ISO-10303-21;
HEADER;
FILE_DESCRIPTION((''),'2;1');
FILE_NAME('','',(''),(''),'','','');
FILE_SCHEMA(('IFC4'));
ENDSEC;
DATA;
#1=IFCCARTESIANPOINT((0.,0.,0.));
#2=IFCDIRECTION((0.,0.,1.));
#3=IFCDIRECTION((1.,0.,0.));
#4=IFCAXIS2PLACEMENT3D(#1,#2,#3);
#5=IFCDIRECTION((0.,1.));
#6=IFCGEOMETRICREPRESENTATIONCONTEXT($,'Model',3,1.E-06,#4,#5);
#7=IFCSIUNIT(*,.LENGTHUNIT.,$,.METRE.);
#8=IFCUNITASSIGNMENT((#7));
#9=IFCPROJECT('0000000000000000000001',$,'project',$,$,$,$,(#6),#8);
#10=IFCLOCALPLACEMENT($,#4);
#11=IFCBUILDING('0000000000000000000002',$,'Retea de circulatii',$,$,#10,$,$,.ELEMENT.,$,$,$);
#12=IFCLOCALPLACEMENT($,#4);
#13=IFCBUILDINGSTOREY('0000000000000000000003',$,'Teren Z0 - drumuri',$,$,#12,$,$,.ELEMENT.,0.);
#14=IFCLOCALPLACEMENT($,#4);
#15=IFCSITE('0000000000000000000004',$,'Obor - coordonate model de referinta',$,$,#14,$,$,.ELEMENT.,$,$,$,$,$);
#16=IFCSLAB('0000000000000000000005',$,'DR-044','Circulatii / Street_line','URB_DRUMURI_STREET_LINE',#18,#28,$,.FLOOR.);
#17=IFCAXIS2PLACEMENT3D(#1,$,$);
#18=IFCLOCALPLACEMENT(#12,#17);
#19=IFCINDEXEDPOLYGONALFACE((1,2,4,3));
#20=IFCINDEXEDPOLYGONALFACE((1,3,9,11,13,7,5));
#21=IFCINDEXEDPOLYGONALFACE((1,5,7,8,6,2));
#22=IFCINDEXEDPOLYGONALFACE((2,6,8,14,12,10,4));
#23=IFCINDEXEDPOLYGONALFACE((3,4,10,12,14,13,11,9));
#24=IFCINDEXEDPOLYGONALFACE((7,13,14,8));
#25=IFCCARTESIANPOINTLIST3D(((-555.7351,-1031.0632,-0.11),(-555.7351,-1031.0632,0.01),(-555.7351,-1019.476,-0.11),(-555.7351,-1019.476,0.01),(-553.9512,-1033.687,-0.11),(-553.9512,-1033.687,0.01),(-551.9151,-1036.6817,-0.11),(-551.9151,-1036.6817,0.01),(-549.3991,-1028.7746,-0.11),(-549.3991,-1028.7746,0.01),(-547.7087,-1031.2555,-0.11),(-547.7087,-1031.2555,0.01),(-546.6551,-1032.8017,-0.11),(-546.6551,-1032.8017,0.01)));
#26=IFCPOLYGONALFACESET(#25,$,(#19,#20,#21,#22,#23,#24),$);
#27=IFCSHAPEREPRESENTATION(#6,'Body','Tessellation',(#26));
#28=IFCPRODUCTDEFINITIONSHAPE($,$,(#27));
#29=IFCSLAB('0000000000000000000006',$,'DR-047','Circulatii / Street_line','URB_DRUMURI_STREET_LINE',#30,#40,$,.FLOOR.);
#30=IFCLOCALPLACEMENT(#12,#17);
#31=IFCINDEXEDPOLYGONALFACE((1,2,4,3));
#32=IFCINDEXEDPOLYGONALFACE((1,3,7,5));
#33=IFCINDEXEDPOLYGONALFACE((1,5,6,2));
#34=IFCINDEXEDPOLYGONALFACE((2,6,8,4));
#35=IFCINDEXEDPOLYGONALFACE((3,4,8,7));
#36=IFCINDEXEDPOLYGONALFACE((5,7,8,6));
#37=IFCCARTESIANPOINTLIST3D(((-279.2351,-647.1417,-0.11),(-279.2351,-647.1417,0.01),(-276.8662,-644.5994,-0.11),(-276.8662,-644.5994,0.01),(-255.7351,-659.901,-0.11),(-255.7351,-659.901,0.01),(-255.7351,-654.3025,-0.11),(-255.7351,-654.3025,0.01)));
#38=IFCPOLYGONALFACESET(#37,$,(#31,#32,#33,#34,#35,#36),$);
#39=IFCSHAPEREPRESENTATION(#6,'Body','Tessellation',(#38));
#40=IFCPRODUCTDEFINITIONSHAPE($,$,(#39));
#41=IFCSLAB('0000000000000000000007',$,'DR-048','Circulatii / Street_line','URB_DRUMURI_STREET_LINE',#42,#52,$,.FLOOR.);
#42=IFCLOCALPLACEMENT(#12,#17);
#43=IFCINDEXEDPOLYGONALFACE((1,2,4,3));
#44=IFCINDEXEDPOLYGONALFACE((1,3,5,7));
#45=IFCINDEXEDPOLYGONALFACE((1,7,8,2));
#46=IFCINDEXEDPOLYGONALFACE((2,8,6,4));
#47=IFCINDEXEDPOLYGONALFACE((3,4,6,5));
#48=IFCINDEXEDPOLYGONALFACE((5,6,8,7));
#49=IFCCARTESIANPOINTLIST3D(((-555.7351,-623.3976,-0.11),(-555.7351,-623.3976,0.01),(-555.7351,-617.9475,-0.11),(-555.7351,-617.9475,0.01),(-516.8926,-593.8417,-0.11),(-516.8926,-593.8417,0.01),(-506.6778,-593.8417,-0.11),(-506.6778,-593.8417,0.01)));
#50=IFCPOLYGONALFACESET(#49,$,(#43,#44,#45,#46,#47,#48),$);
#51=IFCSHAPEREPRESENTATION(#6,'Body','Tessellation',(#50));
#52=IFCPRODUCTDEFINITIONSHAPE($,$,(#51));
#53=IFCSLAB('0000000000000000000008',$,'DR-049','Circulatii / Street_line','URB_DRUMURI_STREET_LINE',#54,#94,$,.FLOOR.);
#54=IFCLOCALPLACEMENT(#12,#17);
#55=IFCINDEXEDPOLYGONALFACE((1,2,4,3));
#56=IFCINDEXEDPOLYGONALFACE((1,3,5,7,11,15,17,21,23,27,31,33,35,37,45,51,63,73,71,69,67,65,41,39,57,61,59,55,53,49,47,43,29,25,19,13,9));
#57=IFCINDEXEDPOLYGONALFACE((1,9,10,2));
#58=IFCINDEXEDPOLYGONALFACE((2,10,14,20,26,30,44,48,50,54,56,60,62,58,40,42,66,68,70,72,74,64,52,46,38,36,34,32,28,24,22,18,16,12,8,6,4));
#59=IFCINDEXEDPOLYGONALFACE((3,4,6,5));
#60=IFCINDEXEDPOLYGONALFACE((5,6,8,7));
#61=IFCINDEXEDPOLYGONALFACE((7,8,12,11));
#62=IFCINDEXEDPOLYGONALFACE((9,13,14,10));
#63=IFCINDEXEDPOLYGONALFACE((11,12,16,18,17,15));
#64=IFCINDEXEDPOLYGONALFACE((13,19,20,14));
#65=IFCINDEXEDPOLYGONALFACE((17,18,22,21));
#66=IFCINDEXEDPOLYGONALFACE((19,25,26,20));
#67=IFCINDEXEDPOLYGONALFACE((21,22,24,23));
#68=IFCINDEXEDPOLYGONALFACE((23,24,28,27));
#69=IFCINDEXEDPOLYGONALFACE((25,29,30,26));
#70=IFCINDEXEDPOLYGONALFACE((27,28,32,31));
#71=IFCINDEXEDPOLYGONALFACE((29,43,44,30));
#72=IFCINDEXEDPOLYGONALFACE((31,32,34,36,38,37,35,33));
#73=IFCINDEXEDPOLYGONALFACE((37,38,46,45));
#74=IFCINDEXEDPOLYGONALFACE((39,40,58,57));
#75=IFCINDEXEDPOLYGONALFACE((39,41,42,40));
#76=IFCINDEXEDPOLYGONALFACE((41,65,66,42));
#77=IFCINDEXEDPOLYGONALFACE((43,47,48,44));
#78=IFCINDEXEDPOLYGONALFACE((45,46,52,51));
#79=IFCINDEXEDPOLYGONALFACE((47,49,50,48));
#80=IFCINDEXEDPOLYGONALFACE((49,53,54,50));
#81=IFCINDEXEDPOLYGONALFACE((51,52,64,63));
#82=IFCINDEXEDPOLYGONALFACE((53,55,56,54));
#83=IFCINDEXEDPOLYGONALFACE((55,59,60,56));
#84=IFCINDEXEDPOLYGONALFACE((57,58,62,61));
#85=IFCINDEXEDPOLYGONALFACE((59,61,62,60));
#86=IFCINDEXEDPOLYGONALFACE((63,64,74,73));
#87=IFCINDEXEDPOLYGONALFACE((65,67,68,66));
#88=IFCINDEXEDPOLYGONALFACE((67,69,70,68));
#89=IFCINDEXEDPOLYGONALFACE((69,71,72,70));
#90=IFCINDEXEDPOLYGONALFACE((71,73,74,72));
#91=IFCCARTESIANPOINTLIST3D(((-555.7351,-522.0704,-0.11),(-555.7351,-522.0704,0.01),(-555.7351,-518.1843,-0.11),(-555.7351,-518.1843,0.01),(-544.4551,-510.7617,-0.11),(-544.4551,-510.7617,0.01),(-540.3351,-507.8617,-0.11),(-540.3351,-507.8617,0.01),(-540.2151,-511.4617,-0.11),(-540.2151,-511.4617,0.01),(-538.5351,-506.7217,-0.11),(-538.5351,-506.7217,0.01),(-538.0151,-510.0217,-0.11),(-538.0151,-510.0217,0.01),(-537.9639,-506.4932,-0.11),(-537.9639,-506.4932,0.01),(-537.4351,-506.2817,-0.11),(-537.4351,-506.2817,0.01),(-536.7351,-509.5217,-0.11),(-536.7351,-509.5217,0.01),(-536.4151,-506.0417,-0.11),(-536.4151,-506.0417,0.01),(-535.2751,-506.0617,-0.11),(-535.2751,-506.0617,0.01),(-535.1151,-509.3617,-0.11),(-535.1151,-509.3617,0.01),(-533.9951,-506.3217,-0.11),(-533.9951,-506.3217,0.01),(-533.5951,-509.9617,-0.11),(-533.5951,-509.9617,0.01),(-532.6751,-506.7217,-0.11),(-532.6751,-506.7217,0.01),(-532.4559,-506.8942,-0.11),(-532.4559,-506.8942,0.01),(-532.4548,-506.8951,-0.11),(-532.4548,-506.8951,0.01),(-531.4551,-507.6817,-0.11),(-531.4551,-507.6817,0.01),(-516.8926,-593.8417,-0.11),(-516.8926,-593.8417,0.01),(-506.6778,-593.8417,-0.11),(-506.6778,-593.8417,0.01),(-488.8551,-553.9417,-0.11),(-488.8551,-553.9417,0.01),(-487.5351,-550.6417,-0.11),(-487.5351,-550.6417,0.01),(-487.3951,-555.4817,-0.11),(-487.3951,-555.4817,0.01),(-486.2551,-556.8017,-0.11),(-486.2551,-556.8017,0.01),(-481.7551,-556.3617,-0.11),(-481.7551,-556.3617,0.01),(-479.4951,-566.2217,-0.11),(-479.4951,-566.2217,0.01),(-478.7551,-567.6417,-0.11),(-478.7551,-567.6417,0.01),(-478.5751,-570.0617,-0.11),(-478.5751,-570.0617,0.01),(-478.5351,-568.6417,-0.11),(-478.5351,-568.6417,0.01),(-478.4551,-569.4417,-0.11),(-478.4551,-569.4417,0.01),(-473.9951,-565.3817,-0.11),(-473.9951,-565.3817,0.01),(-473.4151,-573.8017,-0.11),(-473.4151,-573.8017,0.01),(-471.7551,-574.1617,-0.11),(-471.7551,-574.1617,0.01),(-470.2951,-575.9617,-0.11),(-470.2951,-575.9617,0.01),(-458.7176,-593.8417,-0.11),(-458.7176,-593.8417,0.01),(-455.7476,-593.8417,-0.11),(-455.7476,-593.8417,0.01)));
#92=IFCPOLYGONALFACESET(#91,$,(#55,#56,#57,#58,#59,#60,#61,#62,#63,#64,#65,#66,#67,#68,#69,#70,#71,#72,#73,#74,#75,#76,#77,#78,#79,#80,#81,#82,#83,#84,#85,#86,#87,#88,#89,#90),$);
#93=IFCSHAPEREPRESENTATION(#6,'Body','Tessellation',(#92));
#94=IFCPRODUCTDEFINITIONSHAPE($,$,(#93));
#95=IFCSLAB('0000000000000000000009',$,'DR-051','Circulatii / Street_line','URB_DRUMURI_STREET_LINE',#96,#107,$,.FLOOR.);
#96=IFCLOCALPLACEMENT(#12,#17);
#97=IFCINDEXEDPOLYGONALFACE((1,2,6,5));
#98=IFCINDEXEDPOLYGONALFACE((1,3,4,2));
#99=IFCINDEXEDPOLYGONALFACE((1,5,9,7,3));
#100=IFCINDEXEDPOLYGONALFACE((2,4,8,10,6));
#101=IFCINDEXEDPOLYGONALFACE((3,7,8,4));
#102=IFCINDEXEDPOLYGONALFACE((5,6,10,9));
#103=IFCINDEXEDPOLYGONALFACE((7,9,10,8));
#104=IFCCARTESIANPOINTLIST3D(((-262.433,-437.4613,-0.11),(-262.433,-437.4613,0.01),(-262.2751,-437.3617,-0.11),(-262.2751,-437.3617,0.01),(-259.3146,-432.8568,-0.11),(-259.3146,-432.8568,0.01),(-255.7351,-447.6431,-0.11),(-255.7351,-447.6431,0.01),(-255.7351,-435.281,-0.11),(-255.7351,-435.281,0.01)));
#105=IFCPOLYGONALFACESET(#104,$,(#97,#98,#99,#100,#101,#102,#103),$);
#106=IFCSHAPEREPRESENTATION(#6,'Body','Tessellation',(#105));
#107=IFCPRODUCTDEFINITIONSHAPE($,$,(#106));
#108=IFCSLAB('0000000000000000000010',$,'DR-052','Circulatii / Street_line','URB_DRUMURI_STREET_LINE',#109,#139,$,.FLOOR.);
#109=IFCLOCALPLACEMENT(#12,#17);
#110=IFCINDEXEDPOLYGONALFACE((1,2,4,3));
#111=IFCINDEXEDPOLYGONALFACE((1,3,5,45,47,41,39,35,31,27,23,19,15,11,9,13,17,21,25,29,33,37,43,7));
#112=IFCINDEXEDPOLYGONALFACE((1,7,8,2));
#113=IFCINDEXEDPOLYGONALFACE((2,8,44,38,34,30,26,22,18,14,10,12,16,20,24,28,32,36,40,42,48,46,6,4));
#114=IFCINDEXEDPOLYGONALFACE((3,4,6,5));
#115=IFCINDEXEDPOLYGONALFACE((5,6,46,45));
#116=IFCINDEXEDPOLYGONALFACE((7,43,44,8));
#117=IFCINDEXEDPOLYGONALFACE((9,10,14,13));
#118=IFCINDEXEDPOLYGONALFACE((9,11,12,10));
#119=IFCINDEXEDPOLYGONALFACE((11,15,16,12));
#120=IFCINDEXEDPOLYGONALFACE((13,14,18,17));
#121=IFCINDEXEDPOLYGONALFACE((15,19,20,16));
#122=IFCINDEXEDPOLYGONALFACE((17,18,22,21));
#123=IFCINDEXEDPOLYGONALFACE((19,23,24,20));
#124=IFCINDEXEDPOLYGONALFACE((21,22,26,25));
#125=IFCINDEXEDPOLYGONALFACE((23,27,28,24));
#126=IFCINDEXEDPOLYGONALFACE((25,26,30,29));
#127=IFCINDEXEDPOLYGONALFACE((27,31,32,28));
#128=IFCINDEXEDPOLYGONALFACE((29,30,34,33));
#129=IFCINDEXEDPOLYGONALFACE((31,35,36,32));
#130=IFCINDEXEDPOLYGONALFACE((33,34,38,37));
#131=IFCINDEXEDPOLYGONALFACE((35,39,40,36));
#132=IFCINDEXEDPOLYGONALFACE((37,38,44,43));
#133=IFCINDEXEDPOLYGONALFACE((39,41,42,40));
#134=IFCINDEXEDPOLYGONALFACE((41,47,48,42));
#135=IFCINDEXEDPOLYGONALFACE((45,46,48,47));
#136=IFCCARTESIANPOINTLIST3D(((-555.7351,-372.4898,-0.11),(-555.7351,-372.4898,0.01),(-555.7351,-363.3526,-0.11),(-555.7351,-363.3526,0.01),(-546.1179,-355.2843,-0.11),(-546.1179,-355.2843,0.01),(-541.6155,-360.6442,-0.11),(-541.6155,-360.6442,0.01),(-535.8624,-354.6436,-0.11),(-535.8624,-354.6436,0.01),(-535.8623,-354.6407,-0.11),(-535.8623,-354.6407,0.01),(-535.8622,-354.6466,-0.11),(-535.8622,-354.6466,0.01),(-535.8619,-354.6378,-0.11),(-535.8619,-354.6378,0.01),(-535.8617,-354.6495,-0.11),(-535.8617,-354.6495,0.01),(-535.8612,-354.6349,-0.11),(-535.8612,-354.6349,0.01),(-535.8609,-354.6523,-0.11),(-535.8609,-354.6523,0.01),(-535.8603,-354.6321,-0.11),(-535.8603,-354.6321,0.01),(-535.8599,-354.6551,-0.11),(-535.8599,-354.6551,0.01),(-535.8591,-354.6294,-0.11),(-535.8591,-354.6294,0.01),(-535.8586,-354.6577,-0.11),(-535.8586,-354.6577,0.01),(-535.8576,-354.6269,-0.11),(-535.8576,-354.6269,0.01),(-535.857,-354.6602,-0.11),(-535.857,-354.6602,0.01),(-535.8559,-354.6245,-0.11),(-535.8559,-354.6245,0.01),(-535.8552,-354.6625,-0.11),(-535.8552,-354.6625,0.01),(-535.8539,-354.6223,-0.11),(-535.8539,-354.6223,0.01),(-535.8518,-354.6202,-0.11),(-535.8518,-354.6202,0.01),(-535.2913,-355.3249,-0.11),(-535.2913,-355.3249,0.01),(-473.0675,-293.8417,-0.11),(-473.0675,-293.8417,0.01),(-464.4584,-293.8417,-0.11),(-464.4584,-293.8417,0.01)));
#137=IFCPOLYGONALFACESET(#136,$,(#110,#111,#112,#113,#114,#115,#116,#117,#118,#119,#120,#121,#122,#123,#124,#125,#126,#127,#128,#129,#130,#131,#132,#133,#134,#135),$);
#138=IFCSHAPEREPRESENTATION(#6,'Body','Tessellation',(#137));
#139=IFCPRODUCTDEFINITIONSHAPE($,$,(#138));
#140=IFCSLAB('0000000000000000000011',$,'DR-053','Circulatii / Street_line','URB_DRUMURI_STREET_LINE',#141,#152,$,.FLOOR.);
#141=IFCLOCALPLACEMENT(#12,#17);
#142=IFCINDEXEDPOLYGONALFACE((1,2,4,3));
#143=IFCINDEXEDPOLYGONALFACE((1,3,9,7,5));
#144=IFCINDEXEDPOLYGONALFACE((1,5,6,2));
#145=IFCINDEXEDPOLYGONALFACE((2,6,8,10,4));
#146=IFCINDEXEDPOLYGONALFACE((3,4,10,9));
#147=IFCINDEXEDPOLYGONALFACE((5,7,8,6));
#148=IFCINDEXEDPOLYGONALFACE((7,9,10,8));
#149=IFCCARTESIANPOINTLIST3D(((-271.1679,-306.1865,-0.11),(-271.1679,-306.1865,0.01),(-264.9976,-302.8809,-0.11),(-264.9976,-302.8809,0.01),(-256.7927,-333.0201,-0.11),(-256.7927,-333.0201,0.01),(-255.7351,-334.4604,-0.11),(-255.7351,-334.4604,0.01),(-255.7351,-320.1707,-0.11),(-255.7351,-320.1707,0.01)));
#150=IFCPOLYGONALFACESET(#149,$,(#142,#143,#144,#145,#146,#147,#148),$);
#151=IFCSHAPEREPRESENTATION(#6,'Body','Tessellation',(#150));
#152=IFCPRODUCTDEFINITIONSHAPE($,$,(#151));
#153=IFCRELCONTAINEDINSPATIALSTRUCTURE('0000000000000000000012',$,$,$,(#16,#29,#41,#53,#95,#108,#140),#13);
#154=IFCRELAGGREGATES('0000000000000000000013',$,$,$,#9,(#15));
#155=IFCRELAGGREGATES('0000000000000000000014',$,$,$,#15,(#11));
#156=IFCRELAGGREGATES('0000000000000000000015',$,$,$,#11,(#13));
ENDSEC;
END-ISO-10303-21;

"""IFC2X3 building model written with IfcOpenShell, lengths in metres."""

from ifc_helpers import new_model, si_unit, direction, frame, origin_with_axes, place, context, project, spatial, polyline, outline, extrude, element, save


model = new_model("IFC2X3")

# Units and contexts
model_context = context("Model", 3, precision=1e-06, world=origin_with_axes(), true_north=direction((0.0, 1.0)))
ifc_project = project(units=[si_unit("LENGTHUNIT", "METRE")], contexts=[model_context])

# Site, building, storey
site_placement = place(None, origin_with_axes())
site = spatial("IfcSite", under=ifc_project, at=site_placement, Name="Obor - coordonate model de referinta", CompositionType="ELEMENT")
building_placement = place(None, origin_with_axes())
building = spatial("IfcBuilding", under=site, at=building_placement, Name="Retea de circulatii", CompositionType="ELEMENT")
storey_placement = place(None, origin_with_axes())
storey = spatial("IfcBuildingStorey", under=building, at=storey_placement, Name="Teren Z0 - drumuri", CompositionType="ELEMENT", Elevation=0.0)

# Slabs
slab_1_placement = place(None, origin_with_axes())
element("IfcSlab", 1, at=slab_1_placement, inside=storey, Name="DR-044", Description="Circulatii / Street_line", ObjectType="URB_DRUMURI_STREET_LINE", PredefinedType="FLOOR", context=model_context, shape_type="SweptSolid", body=[
    extrude(outline(polyline([(-547.7087, -1031.2555), (-549.3991, -1028.7746), (-555.7351, -1019.476), (-555.7351, -1031.0632), (-553.9512, -1033.687), (-551.9151, -1036.6817), (-546.6551, -1032.8017), (-547.7087, -1031.2555)])), frame((0.0, 0.0, -0.11), z_axis=(0.0, 0.0, 1.0), x_axis=(1.0, 0.0, 0.0)), (0.0, 0.0, 1.0), 0.12),
])
slab_2_placement = place(None, origin_with_axes())
element("IfcSlab", 2, at=slab_2_placement, inside=storey, Name="DR-047", Description="Circulatii / Street_line", ObjectType="URB_DRUMURI_STREET_LINE", PredefinedType="FLOOR", context=model_context, shape_type="SweptSolid", body=[
    extrude(outline(polyline([(-255.7351, -654.3025), (-276.8662, -644.5994), (-279.2351, -647.1417), (-255.7351, -659.901), (-255.7351, -654.3025)])), frame((0.0, 0.0, -0.11), z_axis=(0.0, 0.0, 1.0), x_axis=(1.0, 0.0, 0.0)), (0.0, 0.0, 1.0), 0.12),
])
slab_3_placement = place(None, origin_with_axes())
element("IfcSlab", 3, at=slab_3_placement, inside=storey, Name="DR-048", Description="Circulatii / Street_line", ObjectType="URB_DRUMURI_STREET_LINE", PredefinedType="FLOOR", context=model_context, shape_type="SweptSolid", body=[
    extrude(outline(polyline([(-516.8926, -593.8417), (-555.7351, -617.9475), (-555.7351, -623.3976), (-506.6778, -593.8417), (-516.8926, -593.8417)])), frame((0.0, 0.0, -0.11), z_axis=(0.0, 0.0, 1.0), x_axis=(1.0, 0.0, 0.0)), (0.0, 0.0, 1.0), 0.12),
])
slab_4_placement = place(None, origin_with_axes())
element("IfcSlab", 4, at=slab_4_placement, inside=storey, Name="DR-049", Description="Circulatii / Street_line", ObjectType="URB_DRUMURI_STREET_LINE", PredefinedType="FLOOR", context=model_context, shape_type="SweptSolid", body=[
    extrude(outline(polyline([(-473.4151, -573.8017), (-471.7551, -574.1617), (-470.2951, -575.9617), (-458.7176, -593.8417), (-455.7476, -593.8417), (-473.9951, -565.3817), (-481.7551, -556.3617), (-487.5351, -550.6417), (-531.4551, -507.6817), (-532.4548, -506.8951), (-532.4559, -506.8942), (-532.6751, -506.7217), (-533.9951, -506.3217), (-535.2751, -506.0617), (-536.4151, -506.0417), (-537.4351, -506.2817), (-537.9639, -506.4932), (-538.5351, -506.7217), (-540.3351, -507.8617), (-544.4551, -510.7617), (-555.7351, -518.1843), (-555.7351, -522.0704), (-540.2151, -511.4617), (-538.0151, -510.0217), (-536.7351, -509.5217), (-535.1151, -509.3617), (-533.5951, -509.9617), (-488.8551, -553.9417), (-487.3951, -555.4817), (-486.2551, -556.8017), (-479.4951, -566.2217), (-478.7551, -567.6417), (-478.5351, -568.6417), (-478.4551, -569.4417), (-478.5751, -570.0617), (-516.8926, -593.8417), (-506.6778, -593.8417), (-473.4151, -573.8017)])), frame((0.0, 0.0, -0.11), z_axis=(0.0, 0.0, 1.0), x_axis=(1.0, 0.0, 0.0)), (0.0, 0.0, 1.0), 0.12),
])
slab_5_placement = place(None, origin_with_axes())
element("IfcSlab", 5, at=slab_5_placement, inside=storey, Name="DR-051", Description="Circulatii / Street_line", ObjectType="URB_DRUMURI_STREET_LINE", PredefinedType="FLOOR", context=model_context, shape_type="SweptSolid", body=[
    extrude(outline(polyline([(-259.3146, -432.8568), (-262.433, -437.4613), (-262.2751, -437.3617), (-255.7351, -447.6431), (-255.7351, -435.281), (-259.3146, -432.8568)])), frame((0.0, 0.0, -0.11), z_axis=(0.0, 0.0, 1.0), x_axis=(1.0, 0.0, 0.0)), (0.0, 0.0, 1.0), 0.12),
])
slab_6_placement = place(None, origin_with_axes())
element("IfcSlab", 6, at=slab_6_placement, inside=storey, Name="DR-052", Description="Circulatii / Street_line", ObjectType="URB_DRUMURI_STREET_LINE", PredefinedType="FLOOR", context=model_context, shape_type="SweptSolid", body=[
    extrude(outline(polyline([(-535.8518, -354.6202), (-464.4584, -293.8417), (-473.0675, -293.8417), (-546.1179, -355.2843), (-555.7351, -363.3526), (-555.7351, -372.4898), (-541.6155, -360.6442), (-535.2913, -355.3249), (-535.8552, -354.6625), (-535.857, -354.6602), (-535.8586, -354.6577), (-535.8599, -354.6551), (-535.8609, -354.6523), (-535.8617, -354.6495), (-535.8622, -354.6466), (-535.8624, -354.6436), (-535.8623, -354.6407), (-535.8619, -354.6378), (-535.8612, -354.6349), (-535.8603, -354.6321), (-535.8591, -354.6294), (-535.8576, -354.6269), (-535.8559, -354.6245), (-535.8539, -354.6223), (-535.8518, -354.6202)])), frame((0.0, 0.0, -0.11), z_axis=(0.0, 0.0, 1.0), x_axis=(1.0, 0.0, 0.0)), (0.0, 0.0, 1.0), 0.12),
])
slab_7_placement = place(None, origin_with_axes())
element("IfcSlab", 7, at=slab_7_placement, inside=storey, Name="DR-053", Description="Circulatii / Street_line", ObjectType="URB_DRUMURI_STREET_LINE", PredefinedType="FLOOR", context=model_context, shape_type="SweptSolid", body=[
    extrude(outline(polyline([(-255.7351, -320.1707), (-264.9976, -302.8809), (-271.1679, -306.1865), (-256.7927, -333.0201), (-255.7351, -334.4604), (-255.7351, -320.1707)])), frame((0.0, 0.0, -0.11), z_axis=(0.0, 0.0, 1.0), x_axis=(1.0, 0.0, 0.0)), (0.0, 0.0, 1.0), 0.12),
])

save(model, "model.ifc")
